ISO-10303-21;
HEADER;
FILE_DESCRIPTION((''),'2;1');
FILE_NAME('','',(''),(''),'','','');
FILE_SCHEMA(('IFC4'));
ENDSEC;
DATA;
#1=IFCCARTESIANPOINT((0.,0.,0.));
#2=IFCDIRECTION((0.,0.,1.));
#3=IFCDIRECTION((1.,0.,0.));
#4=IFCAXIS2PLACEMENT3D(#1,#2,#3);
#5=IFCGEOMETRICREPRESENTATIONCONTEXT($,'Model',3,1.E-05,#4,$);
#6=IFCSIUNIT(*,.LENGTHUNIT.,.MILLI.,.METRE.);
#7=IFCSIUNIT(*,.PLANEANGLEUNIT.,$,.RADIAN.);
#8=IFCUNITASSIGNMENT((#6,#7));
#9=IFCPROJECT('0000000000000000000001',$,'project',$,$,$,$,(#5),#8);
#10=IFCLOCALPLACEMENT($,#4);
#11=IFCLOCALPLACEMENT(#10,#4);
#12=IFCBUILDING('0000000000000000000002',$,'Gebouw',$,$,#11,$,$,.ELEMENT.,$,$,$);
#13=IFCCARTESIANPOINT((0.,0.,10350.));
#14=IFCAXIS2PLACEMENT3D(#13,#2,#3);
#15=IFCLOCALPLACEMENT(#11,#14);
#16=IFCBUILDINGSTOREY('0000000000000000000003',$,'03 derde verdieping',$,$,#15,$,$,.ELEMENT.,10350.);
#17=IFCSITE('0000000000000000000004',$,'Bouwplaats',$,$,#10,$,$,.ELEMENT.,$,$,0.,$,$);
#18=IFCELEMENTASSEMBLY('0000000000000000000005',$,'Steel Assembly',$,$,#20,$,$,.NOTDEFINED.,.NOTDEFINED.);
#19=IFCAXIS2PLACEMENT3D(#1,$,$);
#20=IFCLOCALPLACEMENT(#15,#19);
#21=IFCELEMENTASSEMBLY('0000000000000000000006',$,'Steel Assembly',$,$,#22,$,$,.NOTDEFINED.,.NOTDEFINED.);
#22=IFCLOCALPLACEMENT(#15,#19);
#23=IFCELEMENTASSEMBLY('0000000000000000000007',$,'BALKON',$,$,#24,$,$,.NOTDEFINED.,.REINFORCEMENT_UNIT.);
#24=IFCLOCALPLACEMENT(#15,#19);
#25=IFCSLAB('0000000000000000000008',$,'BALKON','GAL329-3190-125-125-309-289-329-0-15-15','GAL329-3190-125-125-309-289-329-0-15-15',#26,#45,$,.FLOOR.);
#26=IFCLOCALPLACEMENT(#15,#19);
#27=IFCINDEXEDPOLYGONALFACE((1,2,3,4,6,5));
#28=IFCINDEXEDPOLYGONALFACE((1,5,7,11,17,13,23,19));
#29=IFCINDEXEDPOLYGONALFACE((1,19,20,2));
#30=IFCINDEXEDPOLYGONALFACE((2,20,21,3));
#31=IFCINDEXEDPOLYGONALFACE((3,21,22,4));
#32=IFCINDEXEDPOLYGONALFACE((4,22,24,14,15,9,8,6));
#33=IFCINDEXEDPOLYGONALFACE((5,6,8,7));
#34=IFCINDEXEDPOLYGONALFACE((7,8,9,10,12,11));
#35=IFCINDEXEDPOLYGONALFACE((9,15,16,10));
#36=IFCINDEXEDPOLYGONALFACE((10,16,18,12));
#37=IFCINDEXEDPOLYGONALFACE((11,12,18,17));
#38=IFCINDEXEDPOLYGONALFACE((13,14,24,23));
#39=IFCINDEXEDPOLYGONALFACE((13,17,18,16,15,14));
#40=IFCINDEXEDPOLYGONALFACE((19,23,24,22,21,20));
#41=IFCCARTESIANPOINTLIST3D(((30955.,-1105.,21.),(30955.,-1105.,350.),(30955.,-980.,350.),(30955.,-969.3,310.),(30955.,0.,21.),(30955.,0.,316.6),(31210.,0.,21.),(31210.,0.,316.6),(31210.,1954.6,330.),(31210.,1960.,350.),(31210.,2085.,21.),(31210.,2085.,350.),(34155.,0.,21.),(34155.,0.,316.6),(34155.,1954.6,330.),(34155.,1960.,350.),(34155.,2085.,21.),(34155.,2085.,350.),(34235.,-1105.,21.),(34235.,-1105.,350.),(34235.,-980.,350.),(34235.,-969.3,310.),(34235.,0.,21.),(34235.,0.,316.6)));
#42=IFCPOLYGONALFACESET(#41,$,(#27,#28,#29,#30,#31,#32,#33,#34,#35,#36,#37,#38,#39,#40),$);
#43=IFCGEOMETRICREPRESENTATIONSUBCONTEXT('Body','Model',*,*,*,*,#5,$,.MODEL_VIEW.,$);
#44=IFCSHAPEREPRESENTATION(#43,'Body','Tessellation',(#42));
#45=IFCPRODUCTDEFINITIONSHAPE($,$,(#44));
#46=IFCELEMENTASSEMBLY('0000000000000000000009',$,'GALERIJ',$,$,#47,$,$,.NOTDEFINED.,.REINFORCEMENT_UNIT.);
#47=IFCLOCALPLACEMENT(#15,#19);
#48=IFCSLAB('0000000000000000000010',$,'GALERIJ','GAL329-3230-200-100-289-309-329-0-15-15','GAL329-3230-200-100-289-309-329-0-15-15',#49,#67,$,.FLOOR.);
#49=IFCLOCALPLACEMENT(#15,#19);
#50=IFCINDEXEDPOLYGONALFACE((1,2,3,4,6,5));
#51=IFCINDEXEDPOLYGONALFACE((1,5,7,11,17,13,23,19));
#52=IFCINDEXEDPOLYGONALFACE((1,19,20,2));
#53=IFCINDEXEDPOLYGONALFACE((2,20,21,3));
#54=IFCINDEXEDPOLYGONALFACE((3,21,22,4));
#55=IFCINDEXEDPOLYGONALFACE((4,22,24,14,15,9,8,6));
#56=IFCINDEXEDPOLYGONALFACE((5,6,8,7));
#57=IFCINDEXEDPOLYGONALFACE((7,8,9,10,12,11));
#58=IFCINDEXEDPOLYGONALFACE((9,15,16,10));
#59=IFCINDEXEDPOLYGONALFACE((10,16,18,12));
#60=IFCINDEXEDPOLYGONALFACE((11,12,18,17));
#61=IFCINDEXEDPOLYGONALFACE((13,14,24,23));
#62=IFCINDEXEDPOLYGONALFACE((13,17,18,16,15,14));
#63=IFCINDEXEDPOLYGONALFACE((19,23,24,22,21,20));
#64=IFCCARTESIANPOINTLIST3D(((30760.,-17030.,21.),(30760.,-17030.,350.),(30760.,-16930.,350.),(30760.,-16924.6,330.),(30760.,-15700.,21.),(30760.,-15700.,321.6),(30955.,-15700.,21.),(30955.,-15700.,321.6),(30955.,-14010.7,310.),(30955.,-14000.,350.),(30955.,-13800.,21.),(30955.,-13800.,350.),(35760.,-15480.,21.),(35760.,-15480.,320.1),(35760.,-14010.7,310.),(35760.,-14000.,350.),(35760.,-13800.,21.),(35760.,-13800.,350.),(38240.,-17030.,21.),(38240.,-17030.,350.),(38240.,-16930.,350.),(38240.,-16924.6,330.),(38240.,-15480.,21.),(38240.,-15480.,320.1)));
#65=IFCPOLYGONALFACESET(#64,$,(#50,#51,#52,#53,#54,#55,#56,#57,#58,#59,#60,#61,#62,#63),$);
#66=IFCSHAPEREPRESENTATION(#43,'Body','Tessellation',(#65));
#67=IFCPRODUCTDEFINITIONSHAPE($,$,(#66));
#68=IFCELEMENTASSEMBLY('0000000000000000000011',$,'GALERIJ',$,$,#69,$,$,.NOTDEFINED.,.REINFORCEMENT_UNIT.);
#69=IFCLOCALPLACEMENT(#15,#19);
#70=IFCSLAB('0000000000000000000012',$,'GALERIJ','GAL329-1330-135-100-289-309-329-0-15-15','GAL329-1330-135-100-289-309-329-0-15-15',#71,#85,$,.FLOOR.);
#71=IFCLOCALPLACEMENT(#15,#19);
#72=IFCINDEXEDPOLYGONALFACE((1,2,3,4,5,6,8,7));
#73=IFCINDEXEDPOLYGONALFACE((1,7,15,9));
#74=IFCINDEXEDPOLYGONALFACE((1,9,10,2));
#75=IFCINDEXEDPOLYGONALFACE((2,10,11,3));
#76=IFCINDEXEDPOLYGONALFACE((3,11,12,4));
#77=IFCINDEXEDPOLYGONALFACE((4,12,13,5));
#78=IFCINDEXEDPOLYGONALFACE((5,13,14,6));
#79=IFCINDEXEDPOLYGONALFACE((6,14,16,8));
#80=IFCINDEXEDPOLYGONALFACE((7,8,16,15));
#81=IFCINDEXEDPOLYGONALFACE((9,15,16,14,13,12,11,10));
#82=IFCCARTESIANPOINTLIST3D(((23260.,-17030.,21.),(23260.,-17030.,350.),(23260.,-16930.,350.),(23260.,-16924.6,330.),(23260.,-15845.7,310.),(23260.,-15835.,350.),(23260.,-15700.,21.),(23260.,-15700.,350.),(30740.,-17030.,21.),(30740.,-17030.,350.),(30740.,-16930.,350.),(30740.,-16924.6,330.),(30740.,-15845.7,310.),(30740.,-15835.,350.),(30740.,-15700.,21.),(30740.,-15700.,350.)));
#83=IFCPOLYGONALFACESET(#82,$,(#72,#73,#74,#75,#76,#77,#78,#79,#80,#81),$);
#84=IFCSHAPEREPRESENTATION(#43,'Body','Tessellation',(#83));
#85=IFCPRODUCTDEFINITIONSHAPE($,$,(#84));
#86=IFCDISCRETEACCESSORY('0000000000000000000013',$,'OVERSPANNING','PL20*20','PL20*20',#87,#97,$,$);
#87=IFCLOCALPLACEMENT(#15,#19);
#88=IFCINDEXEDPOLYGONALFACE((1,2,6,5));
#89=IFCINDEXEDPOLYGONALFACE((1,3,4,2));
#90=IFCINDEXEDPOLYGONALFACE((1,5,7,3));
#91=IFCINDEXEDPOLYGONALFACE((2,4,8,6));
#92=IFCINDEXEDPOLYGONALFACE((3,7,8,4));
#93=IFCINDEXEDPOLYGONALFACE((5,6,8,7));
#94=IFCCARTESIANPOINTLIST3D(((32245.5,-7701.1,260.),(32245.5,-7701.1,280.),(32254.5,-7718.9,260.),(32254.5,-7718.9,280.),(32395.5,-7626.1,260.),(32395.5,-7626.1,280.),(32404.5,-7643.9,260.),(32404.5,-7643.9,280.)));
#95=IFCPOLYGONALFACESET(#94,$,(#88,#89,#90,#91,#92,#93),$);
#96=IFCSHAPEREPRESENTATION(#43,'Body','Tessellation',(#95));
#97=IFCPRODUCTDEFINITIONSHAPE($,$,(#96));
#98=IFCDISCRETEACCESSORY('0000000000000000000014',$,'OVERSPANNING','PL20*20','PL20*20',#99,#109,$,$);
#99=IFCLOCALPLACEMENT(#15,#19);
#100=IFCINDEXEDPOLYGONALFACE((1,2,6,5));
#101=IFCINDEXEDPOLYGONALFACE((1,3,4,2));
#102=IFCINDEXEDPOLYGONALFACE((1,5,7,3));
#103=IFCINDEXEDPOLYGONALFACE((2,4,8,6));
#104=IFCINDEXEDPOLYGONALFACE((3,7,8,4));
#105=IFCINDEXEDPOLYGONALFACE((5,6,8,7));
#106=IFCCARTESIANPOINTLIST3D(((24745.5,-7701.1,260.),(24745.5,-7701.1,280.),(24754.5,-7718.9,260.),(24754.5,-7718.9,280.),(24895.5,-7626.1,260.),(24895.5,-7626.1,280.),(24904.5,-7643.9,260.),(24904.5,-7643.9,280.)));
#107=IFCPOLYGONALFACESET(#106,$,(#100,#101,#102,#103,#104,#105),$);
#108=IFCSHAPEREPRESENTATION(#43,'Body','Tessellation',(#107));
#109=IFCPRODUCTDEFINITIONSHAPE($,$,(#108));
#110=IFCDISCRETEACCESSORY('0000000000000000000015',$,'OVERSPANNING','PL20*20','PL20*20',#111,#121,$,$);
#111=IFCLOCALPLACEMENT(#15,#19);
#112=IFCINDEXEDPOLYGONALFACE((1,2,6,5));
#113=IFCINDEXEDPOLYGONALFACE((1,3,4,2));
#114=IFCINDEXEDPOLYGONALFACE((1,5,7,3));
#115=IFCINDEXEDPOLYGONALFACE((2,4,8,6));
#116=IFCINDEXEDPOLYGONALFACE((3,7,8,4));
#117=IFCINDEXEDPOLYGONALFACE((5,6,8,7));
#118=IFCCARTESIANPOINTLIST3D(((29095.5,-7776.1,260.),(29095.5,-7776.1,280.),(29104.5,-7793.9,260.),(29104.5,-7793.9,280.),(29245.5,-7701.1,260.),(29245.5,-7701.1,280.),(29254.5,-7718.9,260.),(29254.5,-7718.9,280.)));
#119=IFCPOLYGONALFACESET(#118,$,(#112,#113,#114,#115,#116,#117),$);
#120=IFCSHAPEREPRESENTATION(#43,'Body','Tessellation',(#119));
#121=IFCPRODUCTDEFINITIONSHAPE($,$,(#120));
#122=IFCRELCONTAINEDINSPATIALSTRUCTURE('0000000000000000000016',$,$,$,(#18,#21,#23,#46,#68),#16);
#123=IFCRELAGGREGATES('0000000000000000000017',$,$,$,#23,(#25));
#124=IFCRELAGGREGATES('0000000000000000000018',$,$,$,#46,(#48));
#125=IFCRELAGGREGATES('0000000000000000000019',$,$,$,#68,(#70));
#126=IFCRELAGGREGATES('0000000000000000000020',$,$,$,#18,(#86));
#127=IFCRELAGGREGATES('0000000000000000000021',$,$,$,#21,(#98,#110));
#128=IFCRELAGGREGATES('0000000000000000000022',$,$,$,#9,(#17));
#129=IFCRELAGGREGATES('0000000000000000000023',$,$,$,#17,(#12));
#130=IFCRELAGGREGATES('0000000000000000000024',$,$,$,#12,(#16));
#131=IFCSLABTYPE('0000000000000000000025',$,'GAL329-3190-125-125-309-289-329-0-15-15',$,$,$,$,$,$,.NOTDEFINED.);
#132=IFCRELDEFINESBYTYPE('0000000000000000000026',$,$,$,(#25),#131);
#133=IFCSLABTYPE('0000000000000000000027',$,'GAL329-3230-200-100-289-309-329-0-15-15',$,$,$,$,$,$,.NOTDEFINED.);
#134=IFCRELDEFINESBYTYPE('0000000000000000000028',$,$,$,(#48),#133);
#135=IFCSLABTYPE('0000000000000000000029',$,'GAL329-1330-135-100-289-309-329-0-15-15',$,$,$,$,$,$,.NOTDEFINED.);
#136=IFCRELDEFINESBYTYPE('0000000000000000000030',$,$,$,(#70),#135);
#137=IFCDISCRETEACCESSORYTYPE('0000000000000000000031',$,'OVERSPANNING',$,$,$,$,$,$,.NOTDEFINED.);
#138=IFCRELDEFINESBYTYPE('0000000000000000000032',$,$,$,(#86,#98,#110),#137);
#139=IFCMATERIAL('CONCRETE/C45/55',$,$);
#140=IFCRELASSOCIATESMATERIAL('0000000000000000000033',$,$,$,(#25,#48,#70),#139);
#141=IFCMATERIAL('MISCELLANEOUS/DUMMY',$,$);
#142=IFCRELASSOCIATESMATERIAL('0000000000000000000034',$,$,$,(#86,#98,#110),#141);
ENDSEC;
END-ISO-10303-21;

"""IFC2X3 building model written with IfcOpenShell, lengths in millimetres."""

from ifc_helpers import new_model, si_unit, frame, origin_with_axes, origin_2d_with_axis, place, context, subcontext, project, spatial, polyline, rectangle, outline, extrude, boolean, material, type_object, element, aggregate, save


model = new_model("IFC2X3")

# Units and contexts
model_context = context("Model", 3, precision=1e-05, world=origin_with_axes())
body_context = subcontext(model_context, "Body", "Model", "MODEL_VIEW")
ifc_project = project(units=[si_unit("LENGTHUNIT", "METRE", prefix="MILLI"), si_unit("PLANEANGLEUNIT", "RADIAN")], contexts=[model_context])

# Site, building, storey
site_placement = place(None, origin_with_axes())
site = spatial("IfcSite", under=ifc_project, at=site_placement, Name="Bouwplaats", CompositionType="ELEMENT", RefElevation=0.0)
building_placement = place(site_placement, origin_with_axes())
building = spatial("IfcBuilding", under=site, at=building_placement, Name="Gebouw", CompositionType="ELEMENT")
storey_placement = place(building_placement, frame((0.0, 0.0, 10350.0), z_axis=(0.0, 0.0, 1.0), x_axis=(1.0, 0.0, 0.0)))
storey = spatial("IfcBuildingStorey", under=building, at=storey_placement, Name="03 derde verdieping", CompositionType="ELEMENT", Elevation=10350.0)

# Element assemblies
ifc_material_1 = material(Name="MISCELLANEOUS/DUMMY")
assembly_1_placement = place(storey_placement, origin_with_axes())
assembly_1 = element("IfcElementAssembly", 1, at=assembly_1_placement, inside=storey, Name="Steel Assembly", AssemblyPlace="NOTDEFINED", PredefinedType="NOTDEFINED")
assembly_2_placement = place(storey_placement, origin_with_axes())
assembly_2 = element("IfcElementAssembly", 2, at=assembly_2_placement, inside=storey, Name="Steel Assembly", AssemblyPlace="NOTDEFINED", PredefinedType="NOTDEFINED")

# Element assemblies, slabs
assembly_3_placement = place(storey_placement, origin_with_axes())
assembly_3 = element("IfcElementAssembly", 3, at=assembly_3_placement, inside=storey, Name="BALKON", AssemblyPlace="NOTDEFINED", PredefinedType="REINFORCEMENT_UNIT")
ifc_material_2 = material(Name="CONCRETE/C45/55")
slab_type_1 = type_object("IfcSlabType", Name="GAL329-3190-125-125-309-289-329-0-15-15", PredefinedType="NOTDEFINED")
slab_1_placement = place(assembly_3_placement, frame((30955.0, 490.0, 185.5), z_axis=(0.0, 0.0, 1.0), x_axis=(1.0, 0.0, 0.0)))
slab_1 = element("IfcSlab", 4, at=slab_1_placement, type_object=slab_type_1, material=ifc_material_2, Name="BALKON", Description="GAL329-3190-125-125-309-289-329-0-15-15", ObjectType="GAL329-3190-125-125-309-289-329-0-15-15", PredefinedType="FLOOR", context=body_context, shape_type="CSG", body=[
    boolean("DIFFERENCE", boolean("DIFFERENCE", extrude(outline(polyline([(1595.0, -164.5), (-1595.0, -164.5), (-1595.0, 164.5), (-1470.0, 164.5), (-1464.6, 144.5), (1459.3, 124.5), (1470.0, 164.5), (1595.0, 164.5), (1595.0, -164.5)])), frame((3280.0, 0.0, 0.0), z_axis=(-1.0, 0.0, 0.0), x_axis=(0.0, -1.0, 0.0)), (0.0, 0.0, 1.0), 3280.0), extrude(rectangle(XDim=350.0, YDim=80.0, at=origin_2d_with_axis()), frame((3240.0, 1595.0, -10.5), z_axis=(0.0, -1.0, 0.0), x_axis=(0.0, 0.0, -1.0)), (0.0, 0.0, 1.0), 2085.0)), extrude(rectangle(XDim=350.0, YDim=255.0, at=origin_2d_with_axis()), frame((127.5, -490.0, -10.5), z_axis=(0.0, 1.0, 0.0), x_axis=(0.0, 0.0, -1.0)), (0.0, 0.0, 1.0), 2085.0)),
])
aggregate(assembly_3, [slab_1])
assembly_4_placement = place(storey_placement, origin_with_axes())
assembly_4 = element("IfcElementAssembly", 5, at=assembly_4_placement, inside=storey, Name="GALERIJ", AssemblyPlace="NOTDEFINED", PredefinedType="REINFORCEMENT_UNIT")
slab_type_2 = type_object("IfcSlabType", Name="GAL329-3230-200-100-289-309-329-0-15-15", PredefinedType="NOTDEFINED")
slab_2_placement = place(assembly_4_placement, frame((30760.0, -15415.0, 185.5), z_axis=(0.0, 0.0, 1.0), x_axis=(1.0, 0.0, 0.0)))
slab_2 = element("IfcSlab", 6, at=slab_2_placement, type_object=slab_type_2, material=ifc_material_2, Name="GALERIJ", Description="GAL329-3230-200-100-289-309-329-0-15-15", ObjectType="GAL329-3230-200-100-289-309-329-0-15-15", PredefinedType="FLOOR", context=body_context, shape_type="CSG", body=[
    boolean("DIFFERENCE", boolean("DIFFERENCE", extrude(outline(polyline([(1615.0, -164.5), (-1615.0, -164.5), (-1615.0, 164.5), (-1415.0, 164.5), (-1404.3, 124.5), (1509.6, 144.5), (1515.0, 164.5), (1615.0, 164.5), (1615.0, -164.5)])), frame((7480.0, 0.0, 0.0), z_axis=(-1.0, 0.0, 0.0), x_axis=(0.0, -1.0, 0.0)), (0.0, 0.0, 1.0), 7480.0), extrude(rectangle(XDim=1900.0, YDim=350.0, at=origin_2d_with_axis()), frame((0.0, 665.0, -10.5), z_axis=(1.0, 0.0, 0.0), x_axis=(0.0, 1.0, 0.0)), (0.0, 0.0, 1.0), 195.0)), extrude(rectangle(XDim=1680.0, YDim=350.0, at=origin_2d_with_axis()), frame((5000.0, 775.0, -10.5), z_axis=(1.0, 0.0, 0.0), x_axis=(0.0, 1.0, 0.0)), (0.0, 0.0, 1.0), 2480.0)),
])
aggregate(assembly_4, [slab_2])
assembly_5_placement = place(storey_placement, origin_with_axes())
assembly_5 = element("IfcElementAssembly", 7, at=assembly_5_placement, inside=storey, Name="GALERIJ", AssemblyPlace="NOTDEFINED", PredefinedType="REINFORCEMENT_UNIT")
slab_type_3 = type_object("IfcSlabType", Name="GAL329-1330-135-100-289-309-329-0-15-15", PredefinedType="NOTDEFINED")
slab_3_placement = place(assembly_5_placement, frame((23260.0, -16365.0, 185.5), z_axis=(0.0, 0.0, 1.0), x_axis=(1.0, 0.0, 0.0)))
slab_3 = element("IfcSlab", 8, at=slab_3_placement, type_object=slab_type_3, material=ifc_material_2, Name="GALERIJ", Description="GAL329-1330-135-100-289-309-329-0-15-15", ObjectType="GAL329-1330-135-100-289-309-329-0-15-15", PredefinedType="FLOOR", context=body_context, shape_type="SweptSolid", body=[
    extrude(outline(polyline([(665.0, -164.5), (-665.0, -164.5), (-665.0, 164.5), (-530.0, 164.5), (-519.3, 124.5), (559.6, 144.5), (565.0, 164.5), (665.0, 164.5), (665.0, -164.5)])), frame((7480.0, 0.0, 0.0), z_axis=(-1.0, 0.0, 0.0), x_axis=(0.0, -1.0, 0.0)), (0.0, 0.0, 1.0), 7480.0),
])
aggregate(assembly_5, [slab_3])

# Discrete accessories
discrete_accessory_type = type_object("IfcDiscreteAccessoryType", Name="OVERSPANNING")
discrete_accessory_1_placement = place(assembly_1_placement, frame((32400.0, -7635.0, 270.0), z_axis=(0.447214, -0.894427, 0.0), x_axis=(-0.894427, -0.447214, 0.0)))
discrete_accessory_1 = element("IfcDiscreteAccessory", 9, at=discrete_accessory_1_placement, type_object=discrete_accessory_type, material=ifc_material_1, Name="OVERSPANNING", Description="PL20*20", ObjectType="PL20*20", context=body_context, shape_type="SweptSolid", body=[
    extrude(rectangle(XDim=20.0, YDim=20.0, at=origin_2d_with_axis()), frame((167.7, 0.0, 0.0), z_axis=(-1.0, 0.0, 0.0), x_axis=(0.0, -1.0, 0.0)), (0.0, 0.0, 1.0), 167.7),
])
aggregate(assembly_1, [discrete_accessory_1])
discrete_accessory_2_placement = place(assembly_2_placement, frame((24900.0, -7635.0, 270.0), z_axis=(0.447214, -0.894427, 0.0), x_axis=(-0.894427, -0.447214, 0.0)))
discrete_accessory_2 = element("IfcDiscreteAccessory", 10, at=discrete_accessory_2_placement, type_object=discrete_accessory_type, material=ifc_material_1, Name="OVERSPANNING", Description="PL20*20", ObjectType="PL20*20", context=body_context, shape_type="SweptSolid", body=[
    extrude(rectangle(XDim=20.0, YDim=20.0, at=origin_2d_with_axis()), frame((167.7, 0.0, 0.0), z_axis=(-1.0, 0.0, 0.0), x_axis=(0.0, -1.0, 0.0)), (0.0, 0.0, 1.0), 167.7),
])
discrete_accessory_3_placement = place(assembly_2_placement, frame((29100.0, -7785.0, 270.0), z_axis=(-0.447214, 0.894427, 0.0), x_axis=(0.894427, 0.447214, 0.0)))
discrete_accessory_3 = element("IfcDiscreteAccessory", 11, at=discrete_accessory_3_placement, type_object=discrete_accessory_type, material=ifc_material_1, Name="OVERSPANNING", Description="PL20*20", ObjectType="PL20*20", context=body_context, shape_type="SweptSolid", body=[
    extrude(rectangle(XDim=20.0, YDim=20.0, at=origin_2d_with_axis()), frame((167.7, 0.0, 0.0), z_axis=(-1.0, 0.0, 0.0), x_axis=(0.0, -1.0, 0.0)), (0.0, 0.0, 1.0), 167.7),
])
aggregate(assembly_2, [discrete_accessory_2, discrete_accessory_3])

save(model, "model.ifc")
